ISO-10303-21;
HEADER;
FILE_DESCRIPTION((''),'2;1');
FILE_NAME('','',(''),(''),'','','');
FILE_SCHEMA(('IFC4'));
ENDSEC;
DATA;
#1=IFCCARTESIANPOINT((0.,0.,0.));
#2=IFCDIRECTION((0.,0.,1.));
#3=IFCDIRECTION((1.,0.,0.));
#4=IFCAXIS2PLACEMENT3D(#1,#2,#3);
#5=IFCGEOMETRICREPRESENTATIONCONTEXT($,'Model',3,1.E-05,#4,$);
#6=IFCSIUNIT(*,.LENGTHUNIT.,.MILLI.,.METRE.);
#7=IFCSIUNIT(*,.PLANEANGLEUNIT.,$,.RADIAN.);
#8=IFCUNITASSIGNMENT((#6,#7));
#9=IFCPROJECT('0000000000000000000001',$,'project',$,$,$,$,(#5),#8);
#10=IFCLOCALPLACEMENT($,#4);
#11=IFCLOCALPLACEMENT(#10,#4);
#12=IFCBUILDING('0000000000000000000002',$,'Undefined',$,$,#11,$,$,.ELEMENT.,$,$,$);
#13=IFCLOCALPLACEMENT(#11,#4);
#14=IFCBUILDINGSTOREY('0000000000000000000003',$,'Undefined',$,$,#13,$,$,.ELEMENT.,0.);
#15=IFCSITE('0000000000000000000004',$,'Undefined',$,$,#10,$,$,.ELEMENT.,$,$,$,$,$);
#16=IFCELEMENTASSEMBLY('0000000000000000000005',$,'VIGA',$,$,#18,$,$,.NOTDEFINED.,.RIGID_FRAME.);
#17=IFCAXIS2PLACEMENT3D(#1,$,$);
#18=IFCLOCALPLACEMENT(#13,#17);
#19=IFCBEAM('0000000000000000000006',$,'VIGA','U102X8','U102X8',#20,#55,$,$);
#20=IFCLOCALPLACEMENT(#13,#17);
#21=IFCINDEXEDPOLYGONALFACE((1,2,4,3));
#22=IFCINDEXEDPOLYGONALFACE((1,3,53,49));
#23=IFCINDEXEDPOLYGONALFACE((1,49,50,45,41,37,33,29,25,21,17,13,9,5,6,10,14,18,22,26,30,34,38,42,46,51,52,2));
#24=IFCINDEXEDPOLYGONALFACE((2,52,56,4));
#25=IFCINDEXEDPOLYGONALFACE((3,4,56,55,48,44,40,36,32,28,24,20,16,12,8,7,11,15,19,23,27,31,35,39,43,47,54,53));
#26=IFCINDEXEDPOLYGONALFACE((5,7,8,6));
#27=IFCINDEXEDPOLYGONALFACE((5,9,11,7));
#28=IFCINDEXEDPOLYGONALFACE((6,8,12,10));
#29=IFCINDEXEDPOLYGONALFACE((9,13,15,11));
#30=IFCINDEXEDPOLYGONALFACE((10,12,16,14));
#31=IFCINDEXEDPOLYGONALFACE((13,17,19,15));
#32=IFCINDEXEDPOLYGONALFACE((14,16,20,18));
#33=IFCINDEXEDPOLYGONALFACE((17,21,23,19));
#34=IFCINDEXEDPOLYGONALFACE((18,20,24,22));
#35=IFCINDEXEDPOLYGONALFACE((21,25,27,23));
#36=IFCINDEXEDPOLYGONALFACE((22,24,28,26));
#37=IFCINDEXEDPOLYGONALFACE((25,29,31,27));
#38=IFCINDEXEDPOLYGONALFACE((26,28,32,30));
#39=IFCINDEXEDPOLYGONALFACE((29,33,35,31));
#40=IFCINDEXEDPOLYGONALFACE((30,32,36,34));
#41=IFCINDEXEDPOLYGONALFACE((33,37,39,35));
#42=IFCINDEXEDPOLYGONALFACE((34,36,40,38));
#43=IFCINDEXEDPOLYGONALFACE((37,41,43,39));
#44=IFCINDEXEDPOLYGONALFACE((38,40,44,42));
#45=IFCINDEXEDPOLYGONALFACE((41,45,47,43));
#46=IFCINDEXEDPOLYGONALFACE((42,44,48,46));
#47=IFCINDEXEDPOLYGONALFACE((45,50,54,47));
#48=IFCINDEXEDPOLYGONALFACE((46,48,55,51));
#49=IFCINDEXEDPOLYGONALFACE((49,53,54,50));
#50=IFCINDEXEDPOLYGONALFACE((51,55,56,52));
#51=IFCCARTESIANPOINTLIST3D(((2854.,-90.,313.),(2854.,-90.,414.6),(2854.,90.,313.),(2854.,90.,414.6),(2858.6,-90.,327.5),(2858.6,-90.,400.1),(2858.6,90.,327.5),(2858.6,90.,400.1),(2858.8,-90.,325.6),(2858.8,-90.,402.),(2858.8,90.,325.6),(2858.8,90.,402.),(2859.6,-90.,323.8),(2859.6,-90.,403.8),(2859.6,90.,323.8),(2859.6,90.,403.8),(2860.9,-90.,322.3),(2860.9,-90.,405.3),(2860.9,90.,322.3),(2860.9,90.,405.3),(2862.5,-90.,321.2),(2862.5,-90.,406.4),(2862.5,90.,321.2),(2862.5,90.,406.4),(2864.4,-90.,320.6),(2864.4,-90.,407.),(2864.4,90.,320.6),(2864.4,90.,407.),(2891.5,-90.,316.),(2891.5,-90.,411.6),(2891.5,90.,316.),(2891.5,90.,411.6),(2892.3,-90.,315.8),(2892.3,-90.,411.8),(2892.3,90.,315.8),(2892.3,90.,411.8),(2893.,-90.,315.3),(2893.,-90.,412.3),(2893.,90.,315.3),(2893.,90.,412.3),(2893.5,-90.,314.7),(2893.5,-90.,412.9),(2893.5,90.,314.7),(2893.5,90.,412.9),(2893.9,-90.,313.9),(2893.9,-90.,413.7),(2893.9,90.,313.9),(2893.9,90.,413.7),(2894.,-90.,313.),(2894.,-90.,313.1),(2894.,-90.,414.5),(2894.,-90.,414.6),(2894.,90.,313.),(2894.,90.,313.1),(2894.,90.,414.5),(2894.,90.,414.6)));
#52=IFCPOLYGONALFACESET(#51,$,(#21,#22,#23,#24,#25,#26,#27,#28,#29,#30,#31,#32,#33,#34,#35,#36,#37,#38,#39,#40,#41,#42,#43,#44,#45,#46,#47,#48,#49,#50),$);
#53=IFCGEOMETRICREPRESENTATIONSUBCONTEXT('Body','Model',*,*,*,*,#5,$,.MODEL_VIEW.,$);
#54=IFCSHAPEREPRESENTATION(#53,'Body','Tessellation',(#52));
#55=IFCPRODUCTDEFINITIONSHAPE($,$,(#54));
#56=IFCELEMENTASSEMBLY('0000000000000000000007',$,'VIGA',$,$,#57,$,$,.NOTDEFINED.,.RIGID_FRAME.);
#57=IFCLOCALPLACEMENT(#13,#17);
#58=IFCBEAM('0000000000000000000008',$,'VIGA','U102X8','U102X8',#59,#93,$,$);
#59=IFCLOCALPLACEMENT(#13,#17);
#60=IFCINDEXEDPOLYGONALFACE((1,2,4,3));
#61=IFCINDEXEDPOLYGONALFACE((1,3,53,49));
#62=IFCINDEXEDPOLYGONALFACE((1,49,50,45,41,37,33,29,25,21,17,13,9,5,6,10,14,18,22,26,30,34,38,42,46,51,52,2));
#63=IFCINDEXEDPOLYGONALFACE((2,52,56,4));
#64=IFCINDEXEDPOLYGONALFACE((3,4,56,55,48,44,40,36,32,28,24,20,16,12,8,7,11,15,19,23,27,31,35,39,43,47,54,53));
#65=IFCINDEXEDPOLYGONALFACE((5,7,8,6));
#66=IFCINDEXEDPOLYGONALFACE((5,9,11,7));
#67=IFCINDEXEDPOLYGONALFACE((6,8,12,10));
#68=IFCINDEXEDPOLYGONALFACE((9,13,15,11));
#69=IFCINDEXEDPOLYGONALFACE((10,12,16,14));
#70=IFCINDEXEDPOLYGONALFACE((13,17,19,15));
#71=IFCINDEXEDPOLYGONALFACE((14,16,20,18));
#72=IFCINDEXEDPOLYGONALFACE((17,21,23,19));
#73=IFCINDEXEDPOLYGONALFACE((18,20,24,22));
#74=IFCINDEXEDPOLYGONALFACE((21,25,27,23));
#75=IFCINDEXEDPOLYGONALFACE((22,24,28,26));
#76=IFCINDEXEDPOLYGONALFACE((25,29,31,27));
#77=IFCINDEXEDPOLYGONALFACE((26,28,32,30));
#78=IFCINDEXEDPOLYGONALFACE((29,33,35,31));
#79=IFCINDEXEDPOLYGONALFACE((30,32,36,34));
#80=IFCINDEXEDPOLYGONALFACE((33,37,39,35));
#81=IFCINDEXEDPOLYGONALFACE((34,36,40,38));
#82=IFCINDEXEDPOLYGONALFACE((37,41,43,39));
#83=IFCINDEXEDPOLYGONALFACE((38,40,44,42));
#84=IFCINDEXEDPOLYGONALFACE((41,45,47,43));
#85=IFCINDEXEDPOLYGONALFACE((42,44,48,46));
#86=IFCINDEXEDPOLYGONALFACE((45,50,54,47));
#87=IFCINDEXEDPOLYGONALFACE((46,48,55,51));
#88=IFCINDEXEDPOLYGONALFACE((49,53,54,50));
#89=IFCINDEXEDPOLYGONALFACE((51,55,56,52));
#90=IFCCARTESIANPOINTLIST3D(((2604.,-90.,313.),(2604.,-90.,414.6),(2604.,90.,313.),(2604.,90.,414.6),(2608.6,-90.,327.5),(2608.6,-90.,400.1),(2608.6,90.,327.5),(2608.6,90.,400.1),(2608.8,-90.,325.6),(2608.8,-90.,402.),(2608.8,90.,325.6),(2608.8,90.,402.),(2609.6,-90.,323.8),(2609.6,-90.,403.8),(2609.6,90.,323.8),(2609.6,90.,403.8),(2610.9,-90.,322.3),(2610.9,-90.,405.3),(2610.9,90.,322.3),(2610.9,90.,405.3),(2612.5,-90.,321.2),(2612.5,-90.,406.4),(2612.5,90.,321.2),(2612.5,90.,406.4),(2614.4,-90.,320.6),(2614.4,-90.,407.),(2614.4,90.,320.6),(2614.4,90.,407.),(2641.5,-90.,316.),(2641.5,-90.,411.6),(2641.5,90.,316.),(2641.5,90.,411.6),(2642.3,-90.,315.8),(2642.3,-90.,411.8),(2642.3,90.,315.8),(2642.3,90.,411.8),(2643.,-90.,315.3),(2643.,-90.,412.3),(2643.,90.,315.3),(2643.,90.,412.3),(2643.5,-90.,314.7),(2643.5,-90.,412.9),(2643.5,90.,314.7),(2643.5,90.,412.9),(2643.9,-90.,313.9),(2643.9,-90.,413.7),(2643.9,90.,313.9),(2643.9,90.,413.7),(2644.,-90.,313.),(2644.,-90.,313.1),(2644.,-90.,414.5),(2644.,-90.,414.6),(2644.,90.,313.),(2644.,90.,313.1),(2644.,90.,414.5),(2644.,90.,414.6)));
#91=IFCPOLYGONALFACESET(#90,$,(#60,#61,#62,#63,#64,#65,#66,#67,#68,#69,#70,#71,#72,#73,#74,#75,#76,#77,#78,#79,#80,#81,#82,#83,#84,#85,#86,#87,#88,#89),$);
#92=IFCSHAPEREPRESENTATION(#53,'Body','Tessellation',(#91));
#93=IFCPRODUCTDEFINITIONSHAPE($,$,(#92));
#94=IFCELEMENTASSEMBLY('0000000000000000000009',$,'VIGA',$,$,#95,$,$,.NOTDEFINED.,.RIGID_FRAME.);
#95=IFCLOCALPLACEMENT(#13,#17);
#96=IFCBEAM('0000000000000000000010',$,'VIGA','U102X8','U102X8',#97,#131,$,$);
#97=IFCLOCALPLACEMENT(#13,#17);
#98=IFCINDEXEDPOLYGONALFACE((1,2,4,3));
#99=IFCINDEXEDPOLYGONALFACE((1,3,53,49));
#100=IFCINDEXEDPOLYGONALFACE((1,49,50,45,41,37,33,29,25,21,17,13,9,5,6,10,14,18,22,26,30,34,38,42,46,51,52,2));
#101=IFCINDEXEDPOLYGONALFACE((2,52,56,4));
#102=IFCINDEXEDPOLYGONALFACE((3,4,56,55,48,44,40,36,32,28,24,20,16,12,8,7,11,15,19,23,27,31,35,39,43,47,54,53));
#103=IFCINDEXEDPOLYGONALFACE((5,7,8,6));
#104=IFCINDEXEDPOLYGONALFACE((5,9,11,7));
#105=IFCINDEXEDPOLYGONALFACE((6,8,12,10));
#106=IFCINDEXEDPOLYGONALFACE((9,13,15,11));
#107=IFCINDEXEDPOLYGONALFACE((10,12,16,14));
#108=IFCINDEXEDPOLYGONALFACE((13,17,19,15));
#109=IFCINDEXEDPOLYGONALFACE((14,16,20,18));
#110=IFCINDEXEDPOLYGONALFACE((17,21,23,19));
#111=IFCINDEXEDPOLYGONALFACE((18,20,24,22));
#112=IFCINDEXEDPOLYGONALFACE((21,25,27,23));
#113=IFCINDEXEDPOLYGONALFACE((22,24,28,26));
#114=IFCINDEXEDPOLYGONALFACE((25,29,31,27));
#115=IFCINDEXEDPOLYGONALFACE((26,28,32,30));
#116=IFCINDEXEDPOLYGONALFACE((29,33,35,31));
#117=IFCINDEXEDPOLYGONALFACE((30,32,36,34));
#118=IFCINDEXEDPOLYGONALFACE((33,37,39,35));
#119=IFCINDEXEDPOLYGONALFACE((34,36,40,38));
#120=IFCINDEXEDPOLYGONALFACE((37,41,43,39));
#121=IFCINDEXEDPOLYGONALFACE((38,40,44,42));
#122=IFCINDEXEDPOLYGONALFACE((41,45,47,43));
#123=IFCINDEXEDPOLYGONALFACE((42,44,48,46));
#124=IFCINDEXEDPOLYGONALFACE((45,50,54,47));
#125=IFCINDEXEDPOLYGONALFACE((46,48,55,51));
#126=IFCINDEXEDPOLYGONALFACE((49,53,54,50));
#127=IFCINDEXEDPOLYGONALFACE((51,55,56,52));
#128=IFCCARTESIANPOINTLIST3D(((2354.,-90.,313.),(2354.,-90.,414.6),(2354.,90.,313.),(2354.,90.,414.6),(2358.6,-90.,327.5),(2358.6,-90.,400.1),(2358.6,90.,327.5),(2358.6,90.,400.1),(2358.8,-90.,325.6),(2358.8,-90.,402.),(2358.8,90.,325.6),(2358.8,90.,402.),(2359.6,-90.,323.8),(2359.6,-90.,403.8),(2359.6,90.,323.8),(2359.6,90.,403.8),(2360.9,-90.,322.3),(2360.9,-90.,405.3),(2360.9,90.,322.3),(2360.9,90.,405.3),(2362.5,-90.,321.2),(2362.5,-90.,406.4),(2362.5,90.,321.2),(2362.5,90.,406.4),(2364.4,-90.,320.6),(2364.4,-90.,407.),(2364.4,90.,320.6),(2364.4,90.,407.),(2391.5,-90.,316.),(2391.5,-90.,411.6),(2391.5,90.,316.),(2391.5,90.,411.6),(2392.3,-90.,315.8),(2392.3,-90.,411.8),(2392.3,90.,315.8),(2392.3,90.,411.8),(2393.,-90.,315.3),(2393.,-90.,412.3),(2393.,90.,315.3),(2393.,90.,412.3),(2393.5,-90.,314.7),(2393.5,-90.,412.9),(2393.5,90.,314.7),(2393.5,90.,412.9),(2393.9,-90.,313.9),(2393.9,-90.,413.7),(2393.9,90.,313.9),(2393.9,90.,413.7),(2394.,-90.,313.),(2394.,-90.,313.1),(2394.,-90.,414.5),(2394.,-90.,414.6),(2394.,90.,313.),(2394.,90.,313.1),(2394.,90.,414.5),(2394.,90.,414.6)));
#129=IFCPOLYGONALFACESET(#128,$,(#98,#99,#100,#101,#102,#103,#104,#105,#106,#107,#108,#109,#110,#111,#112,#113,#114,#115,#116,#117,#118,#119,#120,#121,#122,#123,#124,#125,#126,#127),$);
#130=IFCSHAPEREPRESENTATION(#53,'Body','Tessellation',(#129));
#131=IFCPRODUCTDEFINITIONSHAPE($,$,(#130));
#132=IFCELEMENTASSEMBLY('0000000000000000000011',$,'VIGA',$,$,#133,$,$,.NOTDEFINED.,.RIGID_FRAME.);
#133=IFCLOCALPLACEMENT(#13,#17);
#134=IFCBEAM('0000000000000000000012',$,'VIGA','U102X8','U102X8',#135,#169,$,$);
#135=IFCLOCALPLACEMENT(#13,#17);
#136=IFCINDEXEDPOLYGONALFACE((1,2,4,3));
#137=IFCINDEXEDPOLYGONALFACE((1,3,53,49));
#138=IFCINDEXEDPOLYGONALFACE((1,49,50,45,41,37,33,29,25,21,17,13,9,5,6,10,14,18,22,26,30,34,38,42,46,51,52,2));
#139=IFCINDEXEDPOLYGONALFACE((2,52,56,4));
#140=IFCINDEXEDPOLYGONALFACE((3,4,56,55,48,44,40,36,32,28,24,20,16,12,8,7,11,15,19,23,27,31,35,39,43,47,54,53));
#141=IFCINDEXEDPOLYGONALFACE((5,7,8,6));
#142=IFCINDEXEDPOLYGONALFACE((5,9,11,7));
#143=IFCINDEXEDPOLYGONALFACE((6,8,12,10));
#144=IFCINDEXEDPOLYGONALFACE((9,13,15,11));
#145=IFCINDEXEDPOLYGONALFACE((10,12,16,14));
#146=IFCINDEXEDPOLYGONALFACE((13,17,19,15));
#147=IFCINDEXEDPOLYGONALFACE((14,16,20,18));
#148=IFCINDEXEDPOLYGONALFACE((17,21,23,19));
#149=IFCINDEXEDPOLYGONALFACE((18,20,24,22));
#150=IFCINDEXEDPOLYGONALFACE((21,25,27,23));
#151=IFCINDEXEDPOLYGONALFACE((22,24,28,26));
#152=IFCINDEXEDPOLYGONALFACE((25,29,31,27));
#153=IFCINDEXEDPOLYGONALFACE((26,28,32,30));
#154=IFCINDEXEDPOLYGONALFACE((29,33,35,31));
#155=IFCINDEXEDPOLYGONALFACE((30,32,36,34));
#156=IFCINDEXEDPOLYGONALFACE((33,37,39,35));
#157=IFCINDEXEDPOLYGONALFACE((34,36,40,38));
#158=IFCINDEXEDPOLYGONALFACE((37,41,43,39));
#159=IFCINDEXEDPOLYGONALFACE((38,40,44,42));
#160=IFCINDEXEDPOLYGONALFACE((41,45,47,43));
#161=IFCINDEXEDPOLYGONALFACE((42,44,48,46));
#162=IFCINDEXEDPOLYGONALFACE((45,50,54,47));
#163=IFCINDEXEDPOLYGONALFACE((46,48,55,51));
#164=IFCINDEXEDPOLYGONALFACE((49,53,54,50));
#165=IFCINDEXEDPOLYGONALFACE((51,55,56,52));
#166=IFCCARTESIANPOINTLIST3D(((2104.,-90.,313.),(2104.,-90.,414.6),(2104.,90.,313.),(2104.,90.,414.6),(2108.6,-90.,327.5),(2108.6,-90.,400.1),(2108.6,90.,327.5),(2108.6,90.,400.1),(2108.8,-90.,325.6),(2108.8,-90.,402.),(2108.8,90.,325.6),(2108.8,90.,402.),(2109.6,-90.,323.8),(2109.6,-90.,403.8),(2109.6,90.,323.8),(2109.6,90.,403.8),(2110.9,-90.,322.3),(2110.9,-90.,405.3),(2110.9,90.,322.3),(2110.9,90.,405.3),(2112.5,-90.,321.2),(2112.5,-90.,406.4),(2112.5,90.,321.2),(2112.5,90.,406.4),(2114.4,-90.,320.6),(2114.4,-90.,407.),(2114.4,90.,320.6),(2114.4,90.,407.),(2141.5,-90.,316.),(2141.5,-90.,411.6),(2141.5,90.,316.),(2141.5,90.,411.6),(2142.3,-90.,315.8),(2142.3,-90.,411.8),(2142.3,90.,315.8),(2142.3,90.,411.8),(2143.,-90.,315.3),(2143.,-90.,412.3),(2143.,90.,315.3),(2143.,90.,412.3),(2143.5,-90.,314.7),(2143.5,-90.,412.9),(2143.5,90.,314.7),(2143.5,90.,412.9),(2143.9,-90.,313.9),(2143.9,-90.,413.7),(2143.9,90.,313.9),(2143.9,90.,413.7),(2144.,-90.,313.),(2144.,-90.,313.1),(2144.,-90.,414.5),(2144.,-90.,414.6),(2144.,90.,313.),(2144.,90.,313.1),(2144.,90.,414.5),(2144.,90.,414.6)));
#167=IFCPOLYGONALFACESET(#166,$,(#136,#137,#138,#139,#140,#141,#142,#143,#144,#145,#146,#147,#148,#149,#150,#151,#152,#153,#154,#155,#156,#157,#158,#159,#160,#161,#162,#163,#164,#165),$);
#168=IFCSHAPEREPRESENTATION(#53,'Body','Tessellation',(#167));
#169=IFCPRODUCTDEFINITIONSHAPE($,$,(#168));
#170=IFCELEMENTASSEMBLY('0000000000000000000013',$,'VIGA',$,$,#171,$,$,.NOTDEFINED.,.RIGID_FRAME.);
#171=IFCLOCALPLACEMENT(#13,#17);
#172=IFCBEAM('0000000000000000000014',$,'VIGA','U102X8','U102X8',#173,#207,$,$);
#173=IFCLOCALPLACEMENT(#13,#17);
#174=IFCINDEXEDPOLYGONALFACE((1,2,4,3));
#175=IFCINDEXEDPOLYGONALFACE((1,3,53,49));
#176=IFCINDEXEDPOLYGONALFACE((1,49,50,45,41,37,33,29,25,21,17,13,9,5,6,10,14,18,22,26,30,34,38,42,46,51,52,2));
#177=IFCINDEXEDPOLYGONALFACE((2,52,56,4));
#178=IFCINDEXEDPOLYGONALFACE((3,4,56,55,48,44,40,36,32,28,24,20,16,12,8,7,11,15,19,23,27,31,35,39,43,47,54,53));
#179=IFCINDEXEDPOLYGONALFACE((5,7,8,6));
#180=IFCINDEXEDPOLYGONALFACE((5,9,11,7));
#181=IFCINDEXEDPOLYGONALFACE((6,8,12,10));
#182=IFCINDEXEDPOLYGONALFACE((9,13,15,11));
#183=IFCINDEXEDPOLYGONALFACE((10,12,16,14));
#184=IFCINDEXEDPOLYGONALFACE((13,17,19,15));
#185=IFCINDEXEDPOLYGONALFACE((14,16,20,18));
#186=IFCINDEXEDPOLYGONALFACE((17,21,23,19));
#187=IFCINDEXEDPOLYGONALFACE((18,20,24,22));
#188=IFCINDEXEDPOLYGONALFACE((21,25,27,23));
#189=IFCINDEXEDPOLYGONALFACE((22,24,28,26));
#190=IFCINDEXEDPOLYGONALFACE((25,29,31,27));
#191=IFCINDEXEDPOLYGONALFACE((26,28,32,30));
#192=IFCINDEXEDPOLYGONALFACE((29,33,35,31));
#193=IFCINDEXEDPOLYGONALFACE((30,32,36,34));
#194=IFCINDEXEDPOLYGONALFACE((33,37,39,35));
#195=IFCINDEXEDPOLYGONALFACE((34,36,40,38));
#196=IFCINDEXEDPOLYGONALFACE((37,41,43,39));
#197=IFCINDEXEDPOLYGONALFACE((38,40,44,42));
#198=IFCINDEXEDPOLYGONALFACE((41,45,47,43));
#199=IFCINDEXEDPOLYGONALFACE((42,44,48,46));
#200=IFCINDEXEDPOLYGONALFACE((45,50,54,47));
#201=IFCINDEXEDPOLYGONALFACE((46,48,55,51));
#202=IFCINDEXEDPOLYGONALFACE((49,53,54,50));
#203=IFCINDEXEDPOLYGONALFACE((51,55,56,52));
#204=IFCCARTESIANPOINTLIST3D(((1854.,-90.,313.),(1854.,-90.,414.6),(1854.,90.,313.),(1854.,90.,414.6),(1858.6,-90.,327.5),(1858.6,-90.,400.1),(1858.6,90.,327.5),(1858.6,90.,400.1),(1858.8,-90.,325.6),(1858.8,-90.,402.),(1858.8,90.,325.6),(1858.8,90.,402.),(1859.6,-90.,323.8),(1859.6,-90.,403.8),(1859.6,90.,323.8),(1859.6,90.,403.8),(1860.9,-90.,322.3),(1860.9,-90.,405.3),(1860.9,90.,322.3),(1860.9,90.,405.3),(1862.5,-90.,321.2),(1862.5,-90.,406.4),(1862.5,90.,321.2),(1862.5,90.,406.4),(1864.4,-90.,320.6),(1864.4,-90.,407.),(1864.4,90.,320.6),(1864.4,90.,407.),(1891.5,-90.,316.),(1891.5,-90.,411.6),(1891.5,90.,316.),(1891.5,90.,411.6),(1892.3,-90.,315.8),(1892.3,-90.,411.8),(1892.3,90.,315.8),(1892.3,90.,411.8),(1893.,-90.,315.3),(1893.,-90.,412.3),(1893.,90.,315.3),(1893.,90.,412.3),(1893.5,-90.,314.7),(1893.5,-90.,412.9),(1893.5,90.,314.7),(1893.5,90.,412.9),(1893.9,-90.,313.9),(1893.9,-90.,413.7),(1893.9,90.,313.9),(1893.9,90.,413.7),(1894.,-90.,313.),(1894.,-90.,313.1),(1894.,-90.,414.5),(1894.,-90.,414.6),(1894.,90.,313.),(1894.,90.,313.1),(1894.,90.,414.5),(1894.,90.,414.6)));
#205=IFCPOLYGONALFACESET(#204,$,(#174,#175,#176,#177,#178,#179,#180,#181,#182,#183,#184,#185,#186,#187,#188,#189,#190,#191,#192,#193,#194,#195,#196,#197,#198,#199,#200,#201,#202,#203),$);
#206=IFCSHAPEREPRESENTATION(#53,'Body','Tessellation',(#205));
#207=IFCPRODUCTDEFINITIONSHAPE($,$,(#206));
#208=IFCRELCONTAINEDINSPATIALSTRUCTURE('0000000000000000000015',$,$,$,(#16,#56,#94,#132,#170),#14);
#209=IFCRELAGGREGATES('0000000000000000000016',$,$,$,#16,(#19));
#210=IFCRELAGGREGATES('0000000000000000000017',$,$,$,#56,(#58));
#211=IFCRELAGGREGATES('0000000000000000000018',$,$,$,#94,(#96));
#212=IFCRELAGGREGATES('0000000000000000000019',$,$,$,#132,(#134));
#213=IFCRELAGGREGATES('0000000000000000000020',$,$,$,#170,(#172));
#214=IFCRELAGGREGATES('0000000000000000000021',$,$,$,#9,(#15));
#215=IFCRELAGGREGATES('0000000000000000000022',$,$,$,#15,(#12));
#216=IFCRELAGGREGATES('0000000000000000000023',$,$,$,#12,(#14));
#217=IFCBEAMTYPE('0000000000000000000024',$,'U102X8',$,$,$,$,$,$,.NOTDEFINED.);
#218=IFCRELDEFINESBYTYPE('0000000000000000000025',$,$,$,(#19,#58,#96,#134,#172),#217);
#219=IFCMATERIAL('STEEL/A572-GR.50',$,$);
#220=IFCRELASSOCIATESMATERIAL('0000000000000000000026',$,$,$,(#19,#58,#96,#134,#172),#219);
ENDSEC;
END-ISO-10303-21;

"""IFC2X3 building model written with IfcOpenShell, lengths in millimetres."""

from ifc_helpers import new_model, si_unit, frame, origin_with_axes, origin_2d_with_axis, place, context, subcontext, project, spatial, u_section, extrude, material, type_object, element, aggregate, save


model = new_model("IFC2X3")

# Units and contexts
model_context = context("Model", 3, precision=1e-05, world=origin_with_axes())
body_context = subcontext(model_context, "Body", "Model", "MODEL_VIEW")
ifc_project = project(units=[si_unit("LENGTHUNIT", "METRE", prefix="MILLI"), si_unit("PLANEANGLEUNIT", "RADIAN")], contexts=[model_context])

# Site, building, storey
site_placement = place(None, origin_with_axes())
site = spatial("IfcSite", under=ifc_project, at=site_placement, Name="Undefined", CompositionType="ELEMENT")
building_placement = place(site_placement, origin_with_axes())
building = spatial("IfcBuilding", under=site, at=building_placement, Name="Undefined", CompositionType="ELEMENT")
storey_placement = place(building_placement, origin_with_axes())
storey = spatial("IfcBuildingStorey", under=building, at=storey_placement, Name="Undefined", CompositionType="ELEMENT", Elevation=0.0)

# Element assemblies, beams
ifc_material_1 = material(Name="STEEL/A572-GR.50")
beam_type_1 = type_object("IfcBeamType", Name="U102X8", PredefinedType="NOTDEFINED")
assembly_1_placement = place(storey_placement, origin_with_axes())
assembly_1 = element("IfcElementAssembly", 1, at=assembly_1_placement, inside=storey, Name="VIGA", AssemblyPlace="NOTDEFINED", PredefinedType="RIGID_FRAME")
beam_1_placement = place(assembly_1_placement, frame((2874.0, -90.0, 363.8), z_axis=(0.0, 0.0, 1.0), x_axis=(0.0, 1.0, 0.0)))
beam_1 = element("IfcBeam", 2, at=beam_1_placement, type_object=beam_type_1, material=ifc_material_1, Name="VIGA", Description="U102X8", ObjectType="U102X8", context=body_context, shape_type="SweptSolid", body=[
    extrude(u_section(Depth=101.6, FlangeWidth=40.0, WebThickness=4.6, FlangeThickness=6.0, FilletRadius=7.0, EdgeRadius=3.0, FlangeSlope=0.16839, at=origin_2d_with_axis()), frame((180.0, 0.0, 0.0), z_axis=(-1.0, 0.0, 0.0), x_axis=(0.0, -1.0, 0.0)), (0.0, 0.0, 1.0), 180.0),
])
aggregate(assembly_1, [beam_1])
assembly_2_placement = place(storey_placement, origin_with_axes())
assembly_2 = element("IfcElementAssembly", 3, at=assembly_2_placement, inside=storey, Name="VIGA", AssemblyPlace="NOTDEFINED", PredefinedType="RIGID_FRAME")
beam_2_placement = place(assembly_2_placement, frame((2624.0, -90.0, 363.8), z_axis=(0.0, 0.0, 1.0), x_axis=(0.0, 1.0, 0.0)))
beam_2 = element("IfcBeam", 4, at=beam_2_placement, type_object=beam_type_1, material=ifc_material_1, Name="VIGA", Description="U102X8", ObjectType="U102X8", context=body_context, shape_type="SweptSolid", body=[
    extrude(u_section(Depth=101.6, FlangeWidth=40.0, WebThickness=4.6, FlangeThickness=6.0, FilletRadius=7.0, EdgeRadius=3.0, FlangeSlope=0.16839, at=origin_2d_with_axis()), frame((180.0, 0.0, 0.0), z_axis=(-1.0, 0.0, 0.0), x_axis=(0.0, -1.0, 0.0)), (0.0, 0.0, 1.0), 180.0),
])
aggregate(assembly_2, [beam_2])
assembly_3_placement = place(storey_placement, origin_with_axes())
assembly_3 = element("IfcElementAssembly", 5, at=assembly_3_placement, inside=storey, Name="VIGA", AssemblyPlace="NOTDEFINED", PredefinedType="RIGID_FRAME")
beam_3_placement = place(assembly_3_placement, frame((2374.0, -90.0, 363.8), z_axis=(0.0, 0.0, 1.0), x_axis=(0.0, 1.0, 0.0)))
beam_3 = element("IfcBeam", 6, at=beam_3_placement, type_object=beam_type_1, material=ifc_material_1, Name="VIGA", Description="U102X8", ObjectType="U102X8", context=body_context, shape_type="SweptSolid", body=[
    extrude(u_section(Depth=101.6, FlangeWidth=40.0, WebThickness=4.6, FlangeThickness=6.0, FilletRadius=7.0, EdgeRadius=3.0, FlangeSlope=0.16839, at=origin_2d_with_axis()), frame((180.0, 0.0, 0.0), z_axis=(-1.0, 0.0, 0.0), x_axis=(0.0, -1.0, 0.0)), (0.0, 0.0, 1.0), 180.0),
])
aggregate(assembly_3, [beam_3])
assembly_4_placement = place(storey_placement, origin_with_axes())
assembly_4 = element("IfcElementAssembly", 7, at=assembly_4_placement, inside=storey, Name="VIGA", AssemblyPlace="NOTDEFINED", PredefinedType="RIGID_FRAME")
beam_4_placement = place(assembly_4_placement, frame((2124.0, -90.0, 363.8), z_axis=(0.0, 0.0, 1.0), x_axis=(0.0, 1.0, 0.0)))
beam_4 = element("IfcBeam", 8, at=beam_4_placement, type_object=beam_type_1, material=ifc_material_1, Name="VIGA", Description="U102X8", ObjectType="U102X8", context=body_context, shape_type="SweptSolid", body=[
    extrude(u_section(Depth=101.6, FlangeWidth=40.0, WebThickness=4.6, FlangeThickness=6.0, FilletRadius=7.0, EdgeRadius=3.0, FlangeSlope=0.16839, at=origin_2d_with_axis()), frame((180.0, 0.0, 0.0), z_axis=(-1.0, 0.0, 0.0), x_axis=(0.0, -1.0, 0.0)), (0.0, 0.0, 1.0), 180.0),
])
aggregate(assembly_4, [beam_4])
assembly_5_placement = place(storey_placement, origin_with_axes())
assembly_5 = element("IfcElementAssembly", 9, at=assembly_5_placement, inside=storey, Name="VIGA", AssemblyPlace="NOTDEFINED", PredefinedType="RIGID_FRAME")
beam_5_placement = place(assembly_5_placement, frame((1874.0, -90.0, 363.8), z_axis=(0.0, 0.0, 1.0), x_axis=(0.0, 1.0, 0.0)))
beam_5 = element("IfcBeam", 10, at=beam_5_placement, type_object=beam_type_1, material=ifc_material_1, Name="VIGA", Description="U102X8", ObjectType="U102X8", context=body_context, shape_type="SweptSolid", body=[
    extrude(u_section(Depth=101.6, FlangeWidth=40.0, WebThickness=4.6, FlangeThickness=6.0, FilletRadius=7.0, EdgeRadius=3.0, FlangeSlope=0.16839, at=origin_2d_with_axis()), frame((180.0, 0.0, 0.0), z_axis=(-1.0, 0.0, 0.0), x_axis=(0.0, -1.0, 0.0)), (0.0, 0.0, 1.0), 180.0),
])
aggregate(assembly_5, [beam_5])

save(model, "model.ifc")
